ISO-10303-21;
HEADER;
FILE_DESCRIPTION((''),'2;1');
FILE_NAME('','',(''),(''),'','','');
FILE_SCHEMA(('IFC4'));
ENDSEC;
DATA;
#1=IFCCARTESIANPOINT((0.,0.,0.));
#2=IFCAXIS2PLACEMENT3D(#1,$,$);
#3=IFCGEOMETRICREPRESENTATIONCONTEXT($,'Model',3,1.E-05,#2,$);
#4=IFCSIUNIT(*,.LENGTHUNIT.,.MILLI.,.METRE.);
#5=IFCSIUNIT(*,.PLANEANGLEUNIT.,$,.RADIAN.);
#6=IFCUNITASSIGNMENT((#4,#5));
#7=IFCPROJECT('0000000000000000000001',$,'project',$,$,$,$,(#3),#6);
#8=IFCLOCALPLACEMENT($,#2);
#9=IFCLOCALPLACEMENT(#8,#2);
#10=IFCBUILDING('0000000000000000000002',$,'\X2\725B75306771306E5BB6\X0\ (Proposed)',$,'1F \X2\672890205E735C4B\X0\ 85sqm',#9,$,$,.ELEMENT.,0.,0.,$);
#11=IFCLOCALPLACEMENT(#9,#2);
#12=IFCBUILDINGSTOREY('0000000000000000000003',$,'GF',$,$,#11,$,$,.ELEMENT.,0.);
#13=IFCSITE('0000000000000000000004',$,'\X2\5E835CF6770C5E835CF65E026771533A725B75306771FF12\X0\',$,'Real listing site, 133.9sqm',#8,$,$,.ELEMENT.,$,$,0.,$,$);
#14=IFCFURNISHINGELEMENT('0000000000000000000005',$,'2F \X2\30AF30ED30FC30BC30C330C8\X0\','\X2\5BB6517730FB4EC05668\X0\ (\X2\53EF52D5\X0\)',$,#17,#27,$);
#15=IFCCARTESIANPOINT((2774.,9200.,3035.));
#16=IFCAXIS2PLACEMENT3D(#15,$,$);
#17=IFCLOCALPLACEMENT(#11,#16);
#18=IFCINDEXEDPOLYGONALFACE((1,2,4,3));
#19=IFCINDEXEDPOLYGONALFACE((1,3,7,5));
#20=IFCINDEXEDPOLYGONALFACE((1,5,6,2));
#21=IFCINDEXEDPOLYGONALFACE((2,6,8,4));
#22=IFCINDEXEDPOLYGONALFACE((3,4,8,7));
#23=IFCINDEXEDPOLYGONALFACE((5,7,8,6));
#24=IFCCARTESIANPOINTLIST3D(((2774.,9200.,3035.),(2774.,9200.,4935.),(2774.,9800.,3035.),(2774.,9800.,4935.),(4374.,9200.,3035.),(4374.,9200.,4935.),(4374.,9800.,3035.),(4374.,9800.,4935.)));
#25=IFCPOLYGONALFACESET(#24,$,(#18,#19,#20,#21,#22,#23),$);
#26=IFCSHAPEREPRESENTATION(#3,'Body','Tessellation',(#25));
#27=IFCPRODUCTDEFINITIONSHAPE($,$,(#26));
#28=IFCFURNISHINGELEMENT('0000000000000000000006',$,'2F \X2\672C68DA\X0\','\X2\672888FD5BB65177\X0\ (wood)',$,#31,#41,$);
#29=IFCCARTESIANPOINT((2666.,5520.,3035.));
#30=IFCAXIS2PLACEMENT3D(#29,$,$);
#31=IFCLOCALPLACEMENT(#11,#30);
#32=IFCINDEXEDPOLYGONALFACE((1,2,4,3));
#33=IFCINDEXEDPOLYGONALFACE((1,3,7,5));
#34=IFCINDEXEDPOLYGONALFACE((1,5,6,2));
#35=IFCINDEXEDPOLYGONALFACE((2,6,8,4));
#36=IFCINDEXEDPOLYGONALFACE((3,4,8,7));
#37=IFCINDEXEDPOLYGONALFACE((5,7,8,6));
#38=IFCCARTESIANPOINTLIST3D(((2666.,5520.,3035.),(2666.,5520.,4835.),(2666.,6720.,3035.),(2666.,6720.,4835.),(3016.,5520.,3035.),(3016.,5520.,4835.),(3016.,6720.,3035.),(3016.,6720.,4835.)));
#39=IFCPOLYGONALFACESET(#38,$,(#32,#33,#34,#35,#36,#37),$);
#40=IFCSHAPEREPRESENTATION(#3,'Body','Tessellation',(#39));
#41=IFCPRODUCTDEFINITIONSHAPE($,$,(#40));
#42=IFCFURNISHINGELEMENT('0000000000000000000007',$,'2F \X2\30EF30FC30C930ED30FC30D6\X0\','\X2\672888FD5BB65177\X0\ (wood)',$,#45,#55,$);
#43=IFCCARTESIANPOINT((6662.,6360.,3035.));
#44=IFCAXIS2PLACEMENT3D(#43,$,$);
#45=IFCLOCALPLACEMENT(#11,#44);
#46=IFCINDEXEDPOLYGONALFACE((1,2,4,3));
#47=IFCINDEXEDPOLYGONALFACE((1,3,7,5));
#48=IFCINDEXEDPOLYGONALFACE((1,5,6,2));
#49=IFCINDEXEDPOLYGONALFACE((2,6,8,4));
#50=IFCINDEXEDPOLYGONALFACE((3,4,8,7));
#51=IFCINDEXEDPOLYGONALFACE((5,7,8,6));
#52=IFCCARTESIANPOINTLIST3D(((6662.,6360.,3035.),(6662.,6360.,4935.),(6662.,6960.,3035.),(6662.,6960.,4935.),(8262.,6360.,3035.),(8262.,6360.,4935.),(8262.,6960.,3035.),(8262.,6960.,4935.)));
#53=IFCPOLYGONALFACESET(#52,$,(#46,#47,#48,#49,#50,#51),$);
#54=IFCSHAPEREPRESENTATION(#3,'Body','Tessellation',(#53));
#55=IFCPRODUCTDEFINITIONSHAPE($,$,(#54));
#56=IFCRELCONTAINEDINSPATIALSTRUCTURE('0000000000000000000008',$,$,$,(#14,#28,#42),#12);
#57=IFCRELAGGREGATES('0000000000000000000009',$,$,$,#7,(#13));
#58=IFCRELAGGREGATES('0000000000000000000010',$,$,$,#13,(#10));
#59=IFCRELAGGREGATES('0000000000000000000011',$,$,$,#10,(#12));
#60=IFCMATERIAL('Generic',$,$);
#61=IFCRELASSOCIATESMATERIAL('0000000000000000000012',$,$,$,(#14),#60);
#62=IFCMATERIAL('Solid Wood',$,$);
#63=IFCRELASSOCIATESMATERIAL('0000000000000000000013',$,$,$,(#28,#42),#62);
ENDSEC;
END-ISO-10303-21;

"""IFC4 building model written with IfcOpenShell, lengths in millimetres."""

from ifc_helpers import new_model, si_unit, frame, frame_2d, origin, place, context, project, spatial, rectangle, extrude, material, element, save


model = new_model("IFC4")

# Units and contexts
model_context = context("Model", 3, precision=1e-05, world=origin())
ifc_project = project(units=[si_unit("LENGTHUNIT", "METRE", prefix="MILLI"), si_unit("PLANEANGLEUNIT", "RADIAN")], contexts=[model_context])

# Site, building, storey
site_placement = place(None, origin())
site = spatial("IfcSite", under=ifc_project, at=site_placement, Name="広島県広島市東区牛田東２", ObjectType="Real listing site, 133.9sqm", CompositionType="ELEMENT", RefElevation=0.0)
building_placement = place(site_placement, origin())
building = spatial("IfcBuilding", under=site, at=building_placement, Name="牛田東の家 (Proposed)", ObjectType="1F 木造平屋 85sqm", CompositionType="ELEMENT", ElevationOfRefHeight=0.0, ElevationOfTerrain=0.0)
storey_placement = place(building_placement, origin())
storey = spatial("IfcBuildingStorey", under=building, at=storey_placement, Name="GF", CompositionType="ELEMENT", Elevation=0.0)

# Shared definitions
ifc_material_1 = material(Name="Solid Wood")

# Shared definitions
ifc_material_2 = material(Name="Generic")

# Furnishing elements
furnishing_1_placement = place(storey_placement, frame((2774.0, 9200.0, 3035.0)))
element("IfcFurnishingElement", 1, at=furnishing_1_placement, inside=storey, material=ifc_material_2, Name="2F クローゼット", Description="家具・什器 (可動)", context=model_context, shape_type="SweptSolid", body=[
    extrude(rectangle(XDim=1600.0, YDim=600.0, at=frame_2d((800.0, 300.0))), frame((2774.0, 9200.0, 3035.0)), (0.0, 0.0, 1.0), 1900.0),
])
furnishing_2_placement = place(storey_placement, frame((2666.0, 5520.0, 3035.0)))
element("IfcFurnishingElement", 2, at=furnishing_2_placement, inside=storey, material=ifc_material_1, Name="2F 本棚", Description="木製家具 (wood)", context=model_context, shape_type="SweptSolid", body=[
    extrude(rectangle(XDim=350.0, YDim=1200.0, at=frame_2d((175.0, 600.0))), frame((2666.0, 5520.0, 3035.0)), (0.0, 0.0, 1.0), 1800.0),
])
furnishing_3_placement = place(storey_placement, frame((6662.0, 6360.0, 3035.0)))
element("IfcFurnishingElement", 3, at=furnishing_3_placement, inside=storey, material=ifc_material_1, Name="2F ワードローブ", Description="木製家具 (wood)", context=model_context, shape_type="SweptSolid", body=[
    extrude(rectangle(XDim=1600.0, YDim=600.0, at=frame_2d((800.0, 300.0))), frame((6662.0, 6360.0, 3035.0)), (0.0, 0.0, 1.0), 1900.0),
])

save(model, "model.ifc")
